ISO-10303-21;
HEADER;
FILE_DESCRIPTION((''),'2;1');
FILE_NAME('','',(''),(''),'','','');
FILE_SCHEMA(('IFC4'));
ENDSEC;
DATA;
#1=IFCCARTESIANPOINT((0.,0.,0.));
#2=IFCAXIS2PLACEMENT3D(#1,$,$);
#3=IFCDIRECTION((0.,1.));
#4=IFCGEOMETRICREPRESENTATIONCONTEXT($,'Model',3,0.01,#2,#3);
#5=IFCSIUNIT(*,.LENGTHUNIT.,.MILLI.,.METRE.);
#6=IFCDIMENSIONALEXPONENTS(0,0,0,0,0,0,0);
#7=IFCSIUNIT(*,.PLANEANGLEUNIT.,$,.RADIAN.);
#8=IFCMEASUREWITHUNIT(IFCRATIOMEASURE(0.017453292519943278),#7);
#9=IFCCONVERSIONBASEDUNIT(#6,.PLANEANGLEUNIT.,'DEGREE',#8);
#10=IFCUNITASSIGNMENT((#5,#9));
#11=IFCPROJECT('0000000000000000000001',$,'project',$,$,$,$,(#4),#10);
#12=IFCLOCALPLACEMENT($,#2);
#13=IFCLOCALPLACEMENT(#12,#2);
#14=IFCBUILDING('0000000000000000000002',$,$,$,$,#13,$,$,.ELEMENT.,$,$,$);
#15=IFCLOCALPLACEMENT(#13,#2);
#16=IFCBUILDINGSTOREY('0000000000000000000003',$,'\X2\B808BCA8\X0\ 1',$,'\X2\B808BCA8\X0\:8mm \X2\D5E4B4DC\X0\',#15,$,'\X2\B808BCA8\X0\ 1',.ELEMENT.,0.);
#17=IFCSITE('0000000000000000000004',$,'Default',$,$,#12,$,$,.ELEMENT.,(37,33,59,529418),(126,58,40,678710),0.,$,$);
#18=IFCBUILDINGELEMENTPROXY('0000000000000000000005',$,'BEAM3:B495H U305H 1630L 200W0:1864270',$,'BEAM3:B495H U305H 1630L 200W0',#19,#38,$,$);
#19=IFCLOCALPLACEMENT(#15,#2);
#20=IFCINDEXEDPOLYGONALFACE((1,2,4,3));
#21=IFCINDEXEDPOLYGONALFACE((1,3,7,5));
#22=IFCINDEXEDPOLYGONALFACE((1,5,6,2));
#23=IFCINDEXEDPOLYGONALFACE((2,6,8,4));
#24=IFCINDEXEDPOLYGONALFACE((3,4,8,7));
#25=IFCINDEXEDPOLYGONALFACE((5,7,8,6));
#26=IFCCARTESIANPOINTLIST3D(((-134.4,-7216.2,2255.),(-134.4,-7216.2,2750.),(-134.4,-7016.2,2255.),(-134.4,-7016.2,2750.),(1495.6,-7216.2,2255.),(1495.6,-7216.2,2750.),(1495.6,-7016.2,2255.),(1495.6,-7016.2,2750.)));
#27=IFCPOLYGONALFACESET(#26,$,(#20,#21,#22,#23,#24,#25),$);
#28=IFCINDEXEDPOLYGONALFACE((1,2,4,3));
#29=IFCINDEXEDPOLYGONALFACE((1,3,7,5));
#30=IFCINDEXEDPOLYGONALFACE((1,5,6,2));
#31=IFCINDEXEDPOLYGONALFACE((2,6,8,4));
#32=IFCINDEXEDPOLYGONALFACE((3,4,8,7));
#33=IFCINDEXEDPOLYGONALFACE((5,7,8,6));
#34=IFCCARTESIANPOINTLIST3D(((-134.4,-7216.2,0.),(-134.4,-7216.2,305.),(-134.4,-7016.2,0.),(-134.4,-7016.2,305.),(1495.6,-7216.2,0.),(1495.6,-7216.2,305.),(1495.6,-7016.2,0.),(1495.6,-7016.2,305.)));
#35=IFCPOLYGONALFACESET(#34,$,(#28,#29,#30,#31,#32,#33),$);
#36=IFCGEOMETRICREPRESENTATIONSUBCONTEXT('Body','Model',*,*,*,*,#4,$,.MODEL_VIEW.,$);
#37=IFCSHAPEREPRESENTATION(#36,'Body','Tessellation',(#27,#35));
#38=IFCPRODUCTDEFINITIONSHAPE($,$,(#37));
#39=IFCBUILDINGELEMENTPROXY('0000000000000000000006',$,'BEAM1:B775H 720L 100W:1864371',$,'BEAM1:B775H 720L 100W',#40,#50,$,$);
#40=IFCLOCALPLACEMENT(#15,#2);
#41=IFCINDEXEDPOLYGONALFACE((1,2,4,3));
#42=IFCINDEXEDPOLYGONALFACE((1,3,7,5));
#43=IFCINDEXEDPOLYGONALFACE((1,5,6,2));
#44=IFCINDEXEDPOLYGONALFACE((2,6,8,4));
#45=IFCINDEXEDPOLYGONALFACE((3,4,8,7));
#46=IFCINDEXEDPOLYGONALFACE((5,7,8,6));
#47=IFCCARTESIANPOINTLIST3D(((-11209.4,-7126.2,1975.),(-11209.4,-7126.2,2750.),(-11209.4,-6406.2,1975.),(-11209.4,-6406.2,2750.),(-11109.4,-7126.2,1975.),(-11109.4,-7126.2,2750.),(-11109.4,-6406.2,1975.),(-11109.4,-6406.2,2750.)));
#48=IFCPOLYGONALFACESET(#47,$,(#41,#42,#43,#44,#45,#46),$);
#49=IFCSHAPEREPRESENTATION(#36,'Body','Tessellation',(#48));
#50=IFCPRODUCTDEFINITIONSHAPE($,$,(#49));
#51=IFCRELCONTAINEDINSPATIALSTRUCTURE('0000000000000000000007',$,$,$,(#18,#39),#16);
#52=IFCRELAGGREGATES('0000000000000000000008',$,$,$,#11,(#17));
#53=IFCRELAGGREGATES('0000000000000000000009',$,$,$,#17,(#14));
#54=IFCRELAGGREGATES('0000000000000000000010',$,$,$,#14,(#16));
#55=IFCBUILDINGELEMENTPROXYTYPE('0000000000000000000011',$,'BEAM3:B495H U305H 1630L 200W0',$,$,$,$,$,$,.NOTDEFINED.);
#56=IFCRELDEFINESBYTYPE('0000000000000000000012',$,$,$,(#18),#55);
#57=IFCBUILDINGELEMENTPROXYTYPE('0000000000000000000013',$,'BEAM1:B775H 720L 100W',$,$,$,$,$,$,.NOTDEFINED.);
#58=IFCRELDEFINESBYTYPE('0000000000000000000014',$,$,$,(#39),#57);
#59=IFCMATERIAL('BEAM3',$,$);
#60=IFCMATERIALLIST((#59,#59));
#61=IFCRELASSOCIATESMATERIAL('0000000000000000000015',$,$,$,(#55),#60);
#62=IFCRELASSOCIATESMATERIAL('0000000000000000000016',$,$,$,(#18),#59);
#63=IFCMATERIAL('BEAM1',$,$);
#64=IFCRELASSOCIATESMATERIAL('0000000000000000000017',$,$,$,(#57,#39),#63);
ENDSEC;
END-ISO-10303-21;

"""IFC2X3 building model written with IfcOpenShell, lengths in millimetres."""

from ifc_helpers import new_model, entity, si_unit, converted_unit, direction, frame, origin, origin_2d_with_axis, place, context, subcontext, project, spatial, rectangle, extrude, source, transform, mapped, material, material_list, type_object, type_shapes, element, save


model = new_model("IFC2X3")

# Units and contexts
model_context = context("Model", 3, precision=0.01, world=origin(), true_north=direction((0.0, 1.0)))
body_context = subcontext(model_context, "Body", "Model", "MODEL_VIEW")
ifc_project = project(units=[si_unit("LENGTHUNIT", "METRE", prefix="MILLI"), converted_unit("PLANEANGLEUNIT", "DEGREE", entity("IfcRatioMeasure", 0.017453292519943278), si_unit("PLANEANGLEUNIT", "RADIAN"), dimensions=[0, 0, 0, 0, 0, 0, 0])], contexts=[model_context])

# Site, building, storey
site_placement = place(None, origin())
site = spatial("IfcSite", under=ifc_project, at=site_placement, Name="Default", CompositionType="ELEMENT", RefLatitude=(37, 33, 59, 529418), RefLongitude=(126, 58, 40, 678710), RefElevation=0.0)
building_placement = place(site_placement, origin())
building = spatial("IfcBuilding", under=site, at=building_placement, CompositionType="ELEMENT")
storey_placement = place(building_placement, origin())
storey = spatial("IfcBuildingStorey", under=building, at=storey_placement, Name="레벨 1", ObjectType="레벨:8mm 헤드", LongName="레벨 1", CompositionType="ELEMENT", Elevation=0.0)

# Building element proxies
ifc_material_1 = material(Name="BEAM3")
ifc_material_list_1 = material_list([ifc_material_1, ifc_material_1])
building_element_proxy_type_1 = type_object("IfcBuildingElementProxyType", Name="BEAM3:B495H U305H 1630L 200W0", PredefinedType="NOTDEFINED", material=ifc_material_list_1)
shared_shape_1 = source(origin(), body_context, "Body", "SweptSolid", [
    extrude(rectangle(XDim=1630.0, YDim=200.0, at=origin_2d_with_axis()), frame((815.0, -100.0, 2255.0)), (0.0, 0.0, 1.0), 495.0),
    extrude(rectangle(XDim=1630.0, YDim=200.0, at=origin_2d_with_axis()), frame((815.0, -100.0, 0.0)), (0.0, 0.0, 1.0), 305.0),
])
type_shapes(building_element_proxy_type_1, [shared_shape_1])
proxy_1_placement = place(storey_placement, frame((-134.4, -7016.2, 0.0)))
element("IfcBuildingElementProxy", 1, at=proxy_1_placement, inside=storey, type_object=building_element_proxy_type_1, material=ifc_material_1, Name="BEAM3:B495H U305H 1630L 200W0:1864270", ObjectType="BEAM3:B495H U305H 1630L 200W0", context=body_context, shape_type="MappedRepresentation", body=[
    mapped(shared_shape_1, transform((0.0, 0.0, 0.0), scale=1.0)),
])
ifc_material_2 = material(Name="BEAM1")
building_element_proxy_type_2 = type_object("IfcBuildingElementProxyType", Name="BEAM1:B775H 720L 100W", PredefinedType="NOTDEFINED", material=ifc_material_2)
shared_shape_2 = source(origin(), body_context, "Body", "SweptSolid", [
    extrude(rectangle(XDim=720.0, YDim=100.0, at=origin_2d_with_axis()), frame((360.0, -50.0, -775.0)), (0.0, 0.0, 1.0), 775.0),
])
type_shapes(building_element_proxy_type_2, [shared_shape_2])
proxy_2_placement = place(storey_placement, frame((-11109.4, -6406.2, 2750.0), z_axis=(0.0, 0.0, 1.0), x_axis=(0.0, -1.0, 0.0)))
element("IfcBuildingElementProxy", 2, at=proxy_2_placement, inside=storey, type_object=building_element_proxy_type_2, material=ifc_material_2, Name="BEAM1:B775H 720L 100W:1864371", ObjectType="BEAM1:B775H 720L 100W", context=body_context, shape_type="MappedRepresentation", body=[
    mapped(shared_shape_2, transform((0.0, 0.0, 0.0), scale=1.0)),
])

save(model, "model.ifc")
